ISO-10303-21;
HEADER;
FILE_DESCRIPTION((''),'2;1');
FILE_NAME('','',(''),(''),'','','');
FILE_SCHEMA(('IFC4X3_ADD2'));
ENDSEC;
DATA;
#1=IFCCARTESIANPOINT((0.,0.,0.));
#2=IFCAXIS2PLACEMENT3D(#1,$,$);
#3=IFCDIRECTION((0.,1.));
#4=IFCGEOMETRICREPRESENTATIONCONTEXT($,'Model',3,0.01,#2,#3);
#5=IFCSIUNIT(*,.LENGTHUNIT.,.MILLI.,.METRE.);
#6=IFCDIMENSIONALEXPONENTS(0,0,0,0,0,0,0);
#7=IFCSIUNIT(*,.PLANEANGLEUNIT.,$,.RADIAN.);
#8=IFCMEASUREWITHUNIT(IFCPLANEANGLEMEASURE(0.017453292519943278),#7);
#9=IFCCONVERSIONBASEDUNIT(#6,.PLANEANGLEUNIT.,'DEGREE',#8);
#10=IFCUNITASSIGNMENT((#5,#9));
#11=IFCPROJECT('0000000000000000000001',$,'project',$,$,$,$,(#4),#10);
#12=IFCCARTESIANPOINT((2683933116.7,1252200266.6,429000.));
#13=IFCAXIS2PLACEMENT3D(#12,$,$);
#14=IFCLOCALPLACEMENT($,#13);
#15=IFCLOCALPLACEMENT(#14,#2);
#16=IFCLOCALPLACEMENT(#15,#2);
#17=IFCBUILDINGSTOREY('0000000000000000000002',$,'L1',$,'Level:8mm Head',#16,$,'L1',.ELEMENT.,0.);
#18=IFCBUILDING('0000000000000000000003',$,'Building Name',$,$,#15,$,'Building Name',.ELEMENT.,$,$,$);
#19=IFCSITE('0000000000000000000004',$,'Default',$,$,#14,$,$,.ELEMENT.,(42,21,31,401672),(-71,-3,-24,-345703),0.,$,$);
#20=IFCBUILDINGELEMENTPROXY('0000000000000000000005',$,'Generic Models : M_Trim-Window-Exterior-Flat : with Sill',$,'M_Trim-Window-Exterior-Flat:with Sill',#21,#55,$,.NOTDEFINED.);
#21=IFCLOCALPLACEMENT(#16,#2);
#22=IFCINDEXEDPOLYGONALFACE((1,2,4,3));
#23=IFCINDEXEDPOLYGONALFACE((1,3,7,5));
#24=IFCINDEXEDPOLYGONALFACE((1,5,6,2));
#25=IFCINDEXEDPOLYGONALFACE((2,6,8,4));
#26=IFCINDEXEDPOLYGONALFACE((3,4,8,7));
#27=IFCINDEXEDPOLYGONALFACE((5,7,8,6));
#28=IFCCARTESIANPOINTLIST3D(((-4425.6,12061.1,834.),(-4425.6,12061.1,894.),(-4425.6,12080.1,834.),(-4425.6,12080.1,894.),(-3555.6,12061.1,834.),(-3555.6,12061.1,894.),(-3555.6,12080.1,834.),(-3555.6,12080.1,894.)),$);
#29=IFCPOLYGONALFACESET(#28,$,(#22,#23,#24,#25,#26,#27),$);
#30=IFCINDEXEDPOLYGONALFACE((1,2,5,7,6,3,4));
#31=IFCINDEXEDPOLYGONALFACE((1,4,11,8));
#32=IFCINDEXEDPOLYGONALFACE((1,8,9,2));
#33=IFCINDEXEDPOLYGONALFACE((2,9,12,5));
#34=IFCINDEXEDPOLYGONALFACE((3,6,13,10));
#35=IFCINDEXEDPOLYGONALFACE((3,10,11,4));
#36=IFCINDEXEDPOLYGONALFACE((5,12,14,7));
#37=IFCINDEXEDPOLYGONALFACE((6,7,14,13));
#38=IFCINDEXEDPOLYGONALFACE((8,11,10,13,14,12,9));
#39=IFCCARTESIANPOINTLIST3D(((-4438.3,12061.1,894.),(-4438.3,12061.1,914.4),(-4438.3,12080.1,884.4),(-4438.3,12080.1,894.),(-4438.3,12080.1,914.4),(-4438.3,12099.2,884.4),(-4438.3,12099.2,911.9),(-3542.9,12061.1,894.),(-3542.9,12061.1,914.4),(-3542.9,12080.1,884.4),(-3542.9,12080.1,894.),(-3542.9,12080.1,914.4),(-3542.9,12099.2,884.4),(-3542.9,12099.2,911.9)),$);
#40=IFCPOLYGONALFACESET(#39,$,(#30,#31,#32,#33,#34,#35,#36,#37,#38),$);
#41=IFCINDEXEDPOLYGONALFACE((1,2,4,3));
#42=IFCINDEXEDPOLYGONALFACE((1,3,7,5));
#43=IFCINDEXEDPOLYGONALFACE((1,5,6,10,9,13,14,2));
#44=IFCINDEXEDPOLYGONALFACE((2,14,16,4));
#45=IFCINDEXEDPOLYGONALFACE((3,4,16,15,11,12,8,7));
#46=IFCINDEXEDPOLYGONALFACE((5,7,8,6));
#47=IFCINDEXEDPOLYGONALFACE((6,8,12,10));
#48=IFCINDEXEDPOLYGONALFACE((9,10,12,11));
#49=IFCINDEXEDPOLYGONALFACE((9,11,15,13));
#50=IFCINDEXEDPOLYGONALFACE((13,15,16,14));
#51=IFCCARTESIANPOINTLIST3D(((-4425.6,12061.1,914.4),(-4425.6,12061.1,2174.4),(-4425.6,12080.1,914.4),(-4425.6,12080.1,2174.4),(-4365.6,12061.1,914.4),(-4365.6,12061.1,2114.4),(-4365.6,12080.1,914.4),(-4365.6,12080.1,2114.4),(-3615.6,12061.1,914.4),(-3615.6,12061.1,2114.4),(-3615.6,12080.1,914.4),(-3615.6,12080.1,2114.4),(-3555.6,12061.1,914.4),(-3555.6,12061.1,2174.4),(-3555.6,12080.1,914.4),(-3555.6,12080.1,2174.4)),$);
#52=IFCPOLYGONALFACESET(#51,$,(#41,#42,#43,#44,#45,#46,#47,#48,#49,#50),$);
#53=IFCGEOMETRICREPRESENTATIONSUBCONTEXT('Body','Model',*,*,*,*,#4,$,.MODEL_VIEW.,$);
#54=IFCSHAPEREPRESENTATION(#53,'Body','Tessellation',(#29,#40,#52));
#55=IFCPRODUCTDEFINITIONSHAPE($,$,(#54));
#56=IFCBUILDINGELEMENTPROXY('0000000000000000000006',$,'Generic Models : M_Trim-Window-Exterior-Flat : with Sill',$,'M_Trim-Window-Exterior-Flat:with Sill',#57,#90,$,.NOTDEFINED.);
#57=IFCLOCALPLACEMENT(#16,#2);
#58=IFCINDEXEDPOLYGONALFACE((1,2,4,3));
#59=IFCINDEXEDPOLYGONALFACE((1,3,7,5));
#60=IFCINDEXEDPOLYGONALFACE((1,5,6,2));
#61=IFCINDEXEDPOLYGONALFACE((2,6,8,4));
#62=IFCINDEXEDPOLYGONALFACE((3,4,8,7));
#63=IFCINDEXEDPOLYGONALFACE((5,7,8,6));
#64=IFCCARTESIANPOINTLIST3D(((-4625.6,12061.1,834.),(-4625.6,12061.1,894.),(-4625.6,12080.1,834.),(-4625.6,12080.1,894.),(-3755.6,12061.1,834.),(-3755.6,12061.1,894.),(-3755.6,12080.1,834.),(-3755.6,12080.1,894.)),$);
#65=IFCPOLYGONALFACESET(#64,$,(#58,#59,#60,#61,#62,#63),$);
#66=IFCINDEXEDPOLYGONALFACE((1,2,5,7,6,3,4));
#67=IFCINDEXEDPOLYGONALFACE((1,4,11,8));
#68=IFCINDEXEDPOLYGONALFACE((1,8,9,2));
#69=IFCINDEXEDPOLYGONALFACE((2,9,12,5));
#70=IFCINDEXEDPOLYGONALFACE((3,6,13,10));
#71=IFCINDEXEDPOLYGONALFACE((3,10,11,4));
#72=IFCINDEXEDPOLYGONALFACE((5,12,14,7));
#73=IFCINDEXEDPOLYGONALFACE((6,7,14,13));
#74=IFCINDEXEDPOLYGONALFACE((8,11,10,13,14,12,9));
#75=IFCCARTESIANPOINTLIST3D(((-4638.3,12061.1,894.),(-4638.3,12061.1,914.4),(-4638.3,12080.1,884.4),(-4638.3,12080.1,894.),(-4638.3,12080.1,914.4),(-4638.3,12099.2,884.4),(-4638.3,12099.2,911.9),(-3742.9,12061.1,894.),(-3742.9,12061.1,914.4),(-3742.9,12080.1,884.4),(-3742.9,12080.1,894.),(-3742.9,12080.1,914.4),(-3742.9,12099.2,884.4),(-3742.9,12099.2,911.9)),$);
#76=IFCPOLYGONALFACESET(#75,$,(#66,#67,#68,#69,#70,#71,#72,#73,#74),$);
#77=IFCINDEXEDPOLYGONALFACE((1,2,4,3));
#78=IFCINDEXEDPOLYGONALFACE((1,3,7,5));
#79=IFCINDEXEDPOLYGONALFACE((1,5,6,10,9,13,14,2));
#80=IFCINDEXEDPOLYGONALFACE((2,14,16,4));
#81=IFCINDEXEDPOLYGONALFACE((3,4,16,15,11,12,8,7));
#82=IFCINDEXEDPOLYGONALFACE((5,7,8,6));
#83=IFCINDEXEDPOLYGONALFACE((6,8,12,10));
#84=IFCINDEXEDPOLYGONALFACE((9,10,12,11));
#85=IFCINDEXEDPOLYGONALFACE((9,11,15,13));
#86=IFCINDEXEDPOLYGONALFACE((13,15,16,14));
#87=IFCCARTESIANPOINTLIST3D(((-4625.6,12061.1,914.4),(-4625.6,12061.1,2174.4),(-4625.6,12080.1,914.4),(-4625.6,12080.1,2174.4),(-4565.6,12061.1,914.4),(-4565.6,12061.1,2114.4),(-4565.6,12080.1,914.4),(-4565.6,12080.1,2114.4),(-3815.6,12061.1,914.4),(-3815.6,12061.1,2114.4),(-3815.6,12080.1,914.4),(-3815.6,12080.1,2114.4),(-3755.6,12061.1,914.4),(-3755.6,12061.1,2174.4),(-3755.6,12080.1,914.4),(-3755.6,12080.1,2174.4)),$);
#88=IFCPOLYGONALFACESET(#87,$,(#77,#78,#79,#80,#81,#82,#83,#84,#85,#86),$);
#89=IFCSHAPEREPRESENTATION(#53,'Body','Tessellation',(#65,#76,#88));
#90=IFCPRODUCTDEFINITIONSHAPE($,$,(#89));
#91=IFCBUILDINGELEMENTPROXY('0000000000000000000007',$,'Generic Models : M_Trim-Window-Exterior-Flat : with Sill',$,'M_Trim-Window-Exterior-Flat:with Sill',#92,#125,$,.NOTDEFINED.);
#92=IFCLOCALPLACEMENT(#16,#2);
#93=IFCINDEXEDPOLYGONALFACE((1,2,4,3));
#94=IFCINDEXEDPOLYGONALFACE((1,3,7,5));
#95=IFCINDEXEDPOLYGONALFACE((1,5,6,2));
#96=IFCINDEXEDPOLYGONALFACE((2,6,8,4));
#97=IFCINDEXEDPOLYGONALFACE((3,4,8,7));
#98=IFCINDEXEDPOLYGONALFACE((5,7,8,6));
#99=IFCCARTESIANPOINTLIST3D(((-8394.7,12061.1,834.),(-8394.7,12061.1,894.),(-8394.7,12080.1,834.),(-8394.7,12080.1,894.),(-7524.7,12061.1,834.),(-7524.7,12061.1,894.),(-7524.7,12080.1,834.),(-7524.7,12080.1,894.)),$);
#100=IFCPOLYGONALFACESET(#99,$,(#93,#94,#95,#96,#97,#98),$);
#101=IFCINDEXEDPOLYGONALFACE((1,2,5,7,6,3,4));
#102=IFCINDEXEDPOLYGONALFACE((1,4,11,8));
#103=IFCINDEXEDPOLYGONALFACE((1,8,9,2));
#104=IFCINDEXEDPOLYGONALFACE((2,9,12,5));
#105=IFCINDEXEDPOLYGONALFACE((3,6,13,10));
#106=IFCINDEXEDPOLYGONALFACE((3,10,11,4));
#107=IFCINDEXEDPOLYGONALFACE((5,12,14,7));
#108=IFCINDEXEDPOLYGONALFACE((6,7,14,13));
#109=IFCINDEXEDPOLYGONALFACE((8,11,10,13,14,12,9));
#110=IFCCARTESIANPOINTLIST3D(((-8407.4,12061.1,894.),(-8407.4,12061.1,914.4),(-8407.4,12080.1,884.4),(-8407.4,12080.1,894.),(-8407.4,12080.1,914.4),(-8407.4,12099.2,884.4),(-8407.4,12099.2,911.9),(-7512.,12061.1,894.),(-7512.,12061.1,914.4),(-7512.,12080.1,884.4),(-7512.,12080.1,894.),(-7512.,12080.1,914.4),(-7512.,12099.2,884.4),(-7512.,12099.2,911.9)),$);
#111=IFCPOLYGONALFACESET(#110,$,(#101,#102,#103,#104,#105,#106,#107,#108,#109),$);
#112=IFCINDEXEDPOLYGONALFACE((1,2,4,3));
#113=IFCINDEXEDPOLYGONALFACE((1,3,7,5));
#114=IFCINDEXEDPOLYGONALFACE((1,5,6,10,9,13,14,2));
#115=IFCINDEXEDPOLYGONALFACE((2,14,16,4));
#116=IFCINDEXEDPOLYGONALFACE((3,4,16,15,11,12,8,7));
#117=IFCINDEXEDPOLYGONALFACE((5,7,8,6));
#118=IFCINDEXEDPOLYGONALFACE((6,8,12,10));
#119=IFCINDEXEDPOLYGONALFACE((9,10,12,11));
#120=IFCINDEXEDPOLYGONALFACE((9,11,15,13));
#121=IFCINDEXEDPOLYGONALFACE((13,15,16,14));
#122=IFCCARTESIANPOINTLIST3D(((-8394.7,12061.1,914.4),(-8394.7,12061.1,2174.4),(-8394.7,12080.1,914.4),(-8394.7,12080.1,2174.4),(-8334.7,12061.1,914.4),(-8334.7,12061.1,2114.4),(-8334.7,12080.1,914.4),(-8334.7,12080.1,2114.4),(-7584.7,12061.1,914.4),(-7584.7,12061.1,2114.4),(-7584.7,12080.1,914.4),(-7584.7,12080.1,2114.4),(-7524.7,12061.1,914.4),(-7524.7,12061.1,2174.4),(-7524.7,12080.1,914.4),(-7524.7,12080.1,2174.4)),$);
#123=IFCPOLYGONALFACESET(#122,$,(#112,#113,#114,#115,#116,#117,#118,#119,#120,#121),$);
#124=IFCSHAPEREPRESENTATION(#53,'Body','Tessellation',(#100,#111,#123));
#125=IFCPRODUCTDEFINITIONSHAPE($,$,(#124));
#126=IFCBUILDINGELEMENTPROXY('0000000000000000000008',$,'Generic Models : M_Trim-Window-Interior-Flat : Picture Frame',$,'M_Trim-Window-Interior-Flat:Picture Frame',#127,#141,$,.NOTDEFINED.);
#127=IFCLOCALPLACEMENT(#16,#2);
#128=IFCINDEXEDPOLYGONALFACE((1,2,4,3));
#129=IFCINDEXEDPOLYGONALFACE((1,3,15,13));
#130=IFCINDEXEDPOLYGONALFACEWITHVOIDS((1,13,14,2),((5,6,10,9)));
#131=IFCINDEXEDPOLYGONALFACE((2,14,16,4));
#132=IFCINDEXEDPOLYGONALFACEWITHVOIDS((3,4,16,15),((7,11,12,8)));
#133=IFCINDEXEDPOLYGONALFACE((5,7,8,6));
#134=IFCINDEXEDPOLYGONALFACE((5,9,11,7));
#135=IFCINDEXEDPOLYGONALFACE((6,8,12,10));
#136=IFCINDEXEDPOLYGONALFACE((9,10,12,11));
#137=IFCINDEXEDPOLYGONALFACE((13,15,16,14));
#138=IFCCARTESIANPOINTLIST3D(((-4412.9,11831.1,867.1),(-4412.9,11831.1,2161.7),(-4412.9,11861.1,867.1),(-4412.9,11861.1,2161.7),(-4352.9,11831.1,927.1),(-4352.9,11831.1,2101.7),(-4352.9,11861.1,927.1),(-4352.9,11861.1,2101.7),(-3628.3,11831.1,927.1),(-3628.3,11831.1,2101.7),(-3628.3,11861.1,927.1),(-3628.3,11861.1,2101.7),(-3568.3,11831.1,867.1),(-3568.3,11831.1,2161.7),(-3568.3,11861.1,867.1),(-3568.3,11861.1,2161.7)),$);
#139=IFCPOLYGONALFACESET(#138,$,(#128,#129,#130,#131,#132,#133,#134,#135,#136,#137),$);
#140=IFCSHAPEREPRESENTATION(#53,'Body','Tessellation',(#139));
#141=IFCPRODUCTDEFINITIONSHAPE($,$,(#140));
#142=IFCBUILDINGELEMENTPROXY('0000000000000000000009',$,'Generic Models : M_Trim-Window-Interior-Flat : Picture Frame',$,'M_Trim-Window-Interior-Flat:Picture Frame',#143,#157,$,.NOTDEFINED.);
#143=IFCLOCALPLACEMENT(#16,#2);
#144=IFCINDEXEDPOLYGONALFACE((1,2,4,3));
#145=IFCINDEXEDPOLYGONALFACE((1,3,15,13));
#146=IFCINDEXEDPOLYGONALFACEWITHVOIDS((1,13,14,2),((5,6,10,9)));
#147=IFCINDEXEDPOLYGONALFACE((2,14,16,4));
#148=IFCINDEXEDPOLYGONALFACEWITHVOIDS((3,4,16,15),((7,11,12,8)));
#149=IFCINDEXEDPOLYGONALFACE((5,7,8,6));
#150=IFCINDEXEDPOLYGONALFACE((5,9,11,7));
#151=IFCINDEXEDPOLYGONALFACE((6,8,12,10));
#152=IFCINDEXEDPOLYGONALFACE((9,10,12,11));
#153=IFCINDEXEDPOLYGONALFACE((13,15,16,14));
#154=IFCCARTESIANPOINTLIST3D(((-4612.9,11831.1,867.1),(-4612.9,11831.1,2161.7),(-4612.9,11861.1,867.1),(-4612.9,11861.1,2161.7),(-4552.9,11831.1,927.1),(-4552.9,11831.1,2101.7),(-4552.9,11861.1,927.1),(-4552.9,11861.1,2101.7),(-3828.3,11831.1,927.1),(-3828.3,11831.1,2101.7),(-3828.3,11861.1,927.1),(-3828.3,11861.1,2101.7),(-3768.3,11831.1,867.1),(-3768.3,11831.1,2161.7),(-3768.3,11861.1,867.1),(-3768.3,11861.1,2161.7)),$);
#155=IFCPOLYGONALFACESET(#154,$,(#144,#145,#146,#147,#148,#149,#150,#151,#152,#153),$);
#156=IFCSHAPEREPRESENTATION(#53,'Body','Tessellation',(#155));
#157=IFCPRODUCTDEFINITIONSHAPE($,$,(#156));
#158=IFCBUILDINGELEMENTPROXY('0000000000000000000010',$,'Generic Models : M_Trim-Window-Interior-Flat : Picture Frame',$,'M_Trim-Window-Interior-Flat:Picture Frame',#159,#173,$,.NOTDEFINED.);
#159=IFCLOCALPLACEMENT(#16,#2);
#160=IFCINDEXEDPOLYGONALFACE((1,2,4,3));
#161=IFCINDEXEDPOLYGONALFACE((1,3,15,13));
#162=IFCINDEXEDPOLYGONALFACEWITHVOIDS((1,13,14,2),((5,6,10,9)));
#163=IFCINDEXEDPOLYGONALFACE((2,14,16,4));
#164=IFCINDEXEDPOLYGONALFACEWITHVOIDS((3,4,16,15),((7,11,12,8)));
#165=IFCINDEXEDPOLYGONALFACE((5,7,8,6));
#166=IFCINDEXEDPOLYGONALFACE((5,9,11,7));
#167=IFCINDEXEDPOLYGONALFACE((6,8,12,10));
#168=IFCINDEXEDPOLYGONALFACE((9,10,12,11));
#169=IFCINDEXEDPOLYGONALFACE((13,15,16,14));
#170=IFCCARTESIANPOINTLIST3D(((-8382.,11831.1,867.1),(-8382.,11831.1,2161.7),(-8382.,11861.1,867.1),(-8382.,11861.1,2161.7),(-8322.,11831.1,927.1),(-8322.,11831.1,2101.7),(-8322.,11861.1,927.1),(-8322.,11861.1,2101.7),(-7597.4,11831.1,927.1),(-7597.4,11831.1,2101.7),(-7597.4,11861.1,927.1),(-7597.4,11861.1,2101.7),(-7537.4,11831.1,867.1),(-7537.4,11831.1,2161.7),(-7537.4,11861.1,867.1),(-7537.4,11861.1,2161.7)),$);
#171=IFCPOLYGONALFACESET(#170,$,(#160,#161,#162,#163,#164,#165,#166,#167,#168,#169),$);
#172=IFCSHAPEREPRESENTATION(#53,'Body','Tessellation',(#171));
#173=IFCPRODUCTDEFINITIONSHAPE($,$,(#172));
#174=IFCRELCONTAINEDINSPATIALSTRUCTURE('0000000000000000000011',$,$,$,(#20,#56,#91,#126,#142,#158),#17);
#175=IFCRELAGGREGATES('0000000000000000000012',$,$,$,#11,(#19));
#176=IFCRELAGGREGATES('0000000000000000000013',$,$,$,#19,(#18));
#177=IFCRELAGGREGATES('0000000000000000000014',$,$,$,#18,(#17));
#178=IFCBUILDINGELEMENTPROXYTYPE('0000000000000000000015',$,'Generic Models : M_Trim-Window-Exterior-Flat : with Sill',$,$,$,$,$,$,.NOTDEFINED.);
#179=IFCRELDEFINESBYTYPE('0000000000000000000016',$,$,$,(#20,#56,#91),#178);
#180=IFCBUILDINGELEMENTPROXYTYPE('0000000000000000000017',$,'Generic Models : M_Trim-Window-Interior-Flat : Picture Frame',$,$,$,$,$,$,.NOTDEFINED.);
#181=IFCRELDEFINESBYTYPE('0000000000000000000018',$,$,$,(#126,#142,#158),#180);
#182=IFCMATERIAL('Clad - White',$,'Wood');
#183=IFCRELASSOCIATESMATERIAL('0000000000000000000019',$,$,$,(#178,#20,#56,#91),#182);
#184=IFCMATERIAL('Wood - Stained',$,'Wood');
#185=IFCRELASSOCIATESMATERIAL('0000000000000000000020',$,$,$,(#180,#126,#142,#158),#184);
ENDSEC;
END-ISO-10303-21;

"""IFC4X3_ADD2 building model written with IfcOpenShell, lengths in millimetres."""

from ifc_helpers import new_model, entity, si_unit, converted_unit, direction, frame, frame_2d, origin, place, context, subcontext, project, spatial, polyline, rectangle, outline, extrude, source, transform, mapped, material, type_object, type_shapes, element, save


model = new_model("IFC4X3_ADD2")

# Units and contexts
model_context = context("Model", 3, precision=0.01, world=origin(), true_north=direction((0.0, 1.0)))
body_context = subcontext(model_context, "Body", "Model", "MODEL_VIEW")
ifc_project = project(units=[si_unit("LENGTHUNIT", "METRE", prefix="MILLI"), converted_unit("PLANEANGLEUNIT", "DEGREE", entity("IfcPlaneAngleMeasure", 0.017453292519943278), si_unit("PLANEANGLEUNIT", "RADIAN"), dimensions=[0, 0, 0, 0, 0, 0, 0])], contexts=[model_context])

# Site, building, storey
site_placement = place(None, frame((2683933116.7, 1252200266.6, 429000.0)))
site = spatial("IfcSite", under=ifc_project, at=site_placement, Name="Default", CompositionType="ELEMENT", RefLatitude=(42, 21, 31, 401672), RefLongitude=(-71, -3, -24, -345703), RefElevation=0.0)
building_placement = place(site_placement, origin())
building = spatial("IfcBuilding", under=site, at=building_placement, Name="Building Name", LongName="Building Name", CompositionType="ELEMENT")
storey_placement = place(building_placement, origin())
storey = spatial("IfcBuildingStorey", under=building, at=storey_placement, Name="L1", ObjectType="Level:8mm Head", LongName="L1", CompositionType="ELEMENT", Elevation=0.0)

# Shared definitions
ifc_material_1 = material(Name="Wood - Stained", Category="Wood")

# Building element proxies
ifc_material_2 = material(Name="Clad - White", Category="Wood")
building_element_proxy_type_1 = type_object("IfcBuildingElementProxyType", Name="Generic Models : M_Trim-Window-Exterior-Flat : with Sill", PredefinedType="NOTDEFINED", material=ifc_material_2)
shared_shape_1 = source(origin(), body_context, "Body", "SweptSolid", [
    extrude(rectangle(XDim=870.0, YDim=60.0, at=frame_2d((0.0, 0.0), x_axis=(1.0, 0.0))), frame((0.0, -1250.4, 0.0), z_axis=(0.0, 0.0, 1.0), x_axis=(-1.0, 0.0, 0.0)), (0.0, 0.0, 1.0), 19.0),
    extrude(outline(polyline([(-19.0, -15.2), (0.0, -15.2), (0.0, -5.7), (19.0, -5.7), (19.0, 14.8), (0.0, 14.8), (-19.0, 12.3), (-19.0, -15.2)])), frame((-447.7, -1214.8, 19.0), z_axis=(1.0, 0.0, 0.0), x_axis=(0.0, 0.0, -1.0)), (0.0, 0.0, 1.0), 895.4),
    extrude(outline(polyline([(-645.0, -435.0), (615.0, -435.0), (615.0, -375.0), (-585.0, -375.0), (-585.0, 375.0), (615.0, 375.0), (615.0, 435.0), (-645.0, 435.0), (-645.0, -435.0)])), frame((0.0, -585.0, 0.0), z_axis=(0.0, 0.0, 1.0), x_axis=(0.0, -1.0, 0.0)), (0.0, 0.0, 1.0), 19.0),
])
type_shapes(building_element_proxy_type_1, [shared_shape_1])
for number, where, z_axis, x_axis, name in (
    (1, (-3990.6, 12061.1, 2114.4), (0.0, 1.0, 0.0), (-1.0, 0.0, 0.0), "Generic Models : M_Trim-Window-Exterior-Flat : with Sill"),
    (2, (-4190.6, 12061.1, 2114.4), (0.0, 1.0, 0.0), (-1.0, 0.0, 0.0), "Generic Models : M_Trim-Window-Exterior-Flat : with Sill"),
    (3, (-7959.7, 12061.1, 2114.4), (0.0, 1.0, 0.0), (-1.0, 0.0, 0.0), "Generic Models : M_Trim-Window-Exterior-Flat : with Sill"),
):
    element("IfcBuildingElementProxy", number, at=place(storey_placement, frame(where, z_axis=z_axis, x_axis=x_axis)), inside=storey, type_object=building_element_proxy_type_1, material=ifc_material_2, Name=name, ObjectType="M_Trim-Window-Exterior-Flat:with Sill", PredefinedType="NOTDEFINED", context=body_context, shape_type="MappedRepresentation", body=[
        mapped(shared_shape_1, transform((0.0, 0.0, 0.0), scale=1.0)),
    ])
building_element_proxy_type_2 = type_object("IfcBuildingElementProxyType", Name="Generic Models : M_Trim-Window-Interior-Flat : Picture Frame", PredefinedType="NOTDEFINED", material=ifc_material_1)
shared_shape_2 = source(origin(), body_context, "Body", "SweptSolid", [
    extrude(outline(polyline([(-422.3, -647.3), (422.3, -647.3), (422.3, 647.3), (-422.3, 647.3), (-422.3, -647.3)]), holes=[polyline([(-362.3, -587.3), (-362.3, 587.3), (362.3, 587.3), (362.3, -587.3), (-362.3, -587.3)])]), frame((0.0, -600.0, 0.0), z_axis=(0.0, 0.0, 1.0), x_axis=(-1.0, 0.0, 0.0)), (0.0, 0.0, 1.0), 30.0),
])
type_shapes(building_element_proxy_type_2, [shared_shape_2])
for number, where, z_axis, x_axis, name in (
    (4, (-3990.6, 11861.1, 2114.4), (0.0, -1.0, 0.0), (1.0, 0.0, 0.0), "Generic Models : M_Trim-Window-Interior-Flat : Picture Frame"),
    (5, (-4190.6, 11861.1, 2114.4), (0.0, -1.0, 0.0), (1.0, 0.0, 0.0), "Generic Models : M_Trim-Window-Interior-Flat : Picture Frame"),
    (6, (-7959.7, 11861.1, 2114.4), (0.0, -1.0, 0.0), (1.0, 0.0, 0.0), "Generic Models : M_Trim-Window-Interior-Flat : Picture Frame"),
):
    element("IfcBuildingElementProxy", number, at=place(storey_placement, frame(where, z_axis=z_axis, x_axis=x_axis)), inside=storey, type_object=building_element_proxy_type_2, material=ifc_material_1, Name=name, ObjectType="M_Trim-Window-Interior-Flat:Picture Frame", PredefinedType="NOTDEFINED", context=body_context, shape_type="MappedRepresentation", body=[
        mapped(shared_shape_2, transform((0.0, 0.0, 0.0), scale=1.0)),
    ])

save(model, "model.ifc")
